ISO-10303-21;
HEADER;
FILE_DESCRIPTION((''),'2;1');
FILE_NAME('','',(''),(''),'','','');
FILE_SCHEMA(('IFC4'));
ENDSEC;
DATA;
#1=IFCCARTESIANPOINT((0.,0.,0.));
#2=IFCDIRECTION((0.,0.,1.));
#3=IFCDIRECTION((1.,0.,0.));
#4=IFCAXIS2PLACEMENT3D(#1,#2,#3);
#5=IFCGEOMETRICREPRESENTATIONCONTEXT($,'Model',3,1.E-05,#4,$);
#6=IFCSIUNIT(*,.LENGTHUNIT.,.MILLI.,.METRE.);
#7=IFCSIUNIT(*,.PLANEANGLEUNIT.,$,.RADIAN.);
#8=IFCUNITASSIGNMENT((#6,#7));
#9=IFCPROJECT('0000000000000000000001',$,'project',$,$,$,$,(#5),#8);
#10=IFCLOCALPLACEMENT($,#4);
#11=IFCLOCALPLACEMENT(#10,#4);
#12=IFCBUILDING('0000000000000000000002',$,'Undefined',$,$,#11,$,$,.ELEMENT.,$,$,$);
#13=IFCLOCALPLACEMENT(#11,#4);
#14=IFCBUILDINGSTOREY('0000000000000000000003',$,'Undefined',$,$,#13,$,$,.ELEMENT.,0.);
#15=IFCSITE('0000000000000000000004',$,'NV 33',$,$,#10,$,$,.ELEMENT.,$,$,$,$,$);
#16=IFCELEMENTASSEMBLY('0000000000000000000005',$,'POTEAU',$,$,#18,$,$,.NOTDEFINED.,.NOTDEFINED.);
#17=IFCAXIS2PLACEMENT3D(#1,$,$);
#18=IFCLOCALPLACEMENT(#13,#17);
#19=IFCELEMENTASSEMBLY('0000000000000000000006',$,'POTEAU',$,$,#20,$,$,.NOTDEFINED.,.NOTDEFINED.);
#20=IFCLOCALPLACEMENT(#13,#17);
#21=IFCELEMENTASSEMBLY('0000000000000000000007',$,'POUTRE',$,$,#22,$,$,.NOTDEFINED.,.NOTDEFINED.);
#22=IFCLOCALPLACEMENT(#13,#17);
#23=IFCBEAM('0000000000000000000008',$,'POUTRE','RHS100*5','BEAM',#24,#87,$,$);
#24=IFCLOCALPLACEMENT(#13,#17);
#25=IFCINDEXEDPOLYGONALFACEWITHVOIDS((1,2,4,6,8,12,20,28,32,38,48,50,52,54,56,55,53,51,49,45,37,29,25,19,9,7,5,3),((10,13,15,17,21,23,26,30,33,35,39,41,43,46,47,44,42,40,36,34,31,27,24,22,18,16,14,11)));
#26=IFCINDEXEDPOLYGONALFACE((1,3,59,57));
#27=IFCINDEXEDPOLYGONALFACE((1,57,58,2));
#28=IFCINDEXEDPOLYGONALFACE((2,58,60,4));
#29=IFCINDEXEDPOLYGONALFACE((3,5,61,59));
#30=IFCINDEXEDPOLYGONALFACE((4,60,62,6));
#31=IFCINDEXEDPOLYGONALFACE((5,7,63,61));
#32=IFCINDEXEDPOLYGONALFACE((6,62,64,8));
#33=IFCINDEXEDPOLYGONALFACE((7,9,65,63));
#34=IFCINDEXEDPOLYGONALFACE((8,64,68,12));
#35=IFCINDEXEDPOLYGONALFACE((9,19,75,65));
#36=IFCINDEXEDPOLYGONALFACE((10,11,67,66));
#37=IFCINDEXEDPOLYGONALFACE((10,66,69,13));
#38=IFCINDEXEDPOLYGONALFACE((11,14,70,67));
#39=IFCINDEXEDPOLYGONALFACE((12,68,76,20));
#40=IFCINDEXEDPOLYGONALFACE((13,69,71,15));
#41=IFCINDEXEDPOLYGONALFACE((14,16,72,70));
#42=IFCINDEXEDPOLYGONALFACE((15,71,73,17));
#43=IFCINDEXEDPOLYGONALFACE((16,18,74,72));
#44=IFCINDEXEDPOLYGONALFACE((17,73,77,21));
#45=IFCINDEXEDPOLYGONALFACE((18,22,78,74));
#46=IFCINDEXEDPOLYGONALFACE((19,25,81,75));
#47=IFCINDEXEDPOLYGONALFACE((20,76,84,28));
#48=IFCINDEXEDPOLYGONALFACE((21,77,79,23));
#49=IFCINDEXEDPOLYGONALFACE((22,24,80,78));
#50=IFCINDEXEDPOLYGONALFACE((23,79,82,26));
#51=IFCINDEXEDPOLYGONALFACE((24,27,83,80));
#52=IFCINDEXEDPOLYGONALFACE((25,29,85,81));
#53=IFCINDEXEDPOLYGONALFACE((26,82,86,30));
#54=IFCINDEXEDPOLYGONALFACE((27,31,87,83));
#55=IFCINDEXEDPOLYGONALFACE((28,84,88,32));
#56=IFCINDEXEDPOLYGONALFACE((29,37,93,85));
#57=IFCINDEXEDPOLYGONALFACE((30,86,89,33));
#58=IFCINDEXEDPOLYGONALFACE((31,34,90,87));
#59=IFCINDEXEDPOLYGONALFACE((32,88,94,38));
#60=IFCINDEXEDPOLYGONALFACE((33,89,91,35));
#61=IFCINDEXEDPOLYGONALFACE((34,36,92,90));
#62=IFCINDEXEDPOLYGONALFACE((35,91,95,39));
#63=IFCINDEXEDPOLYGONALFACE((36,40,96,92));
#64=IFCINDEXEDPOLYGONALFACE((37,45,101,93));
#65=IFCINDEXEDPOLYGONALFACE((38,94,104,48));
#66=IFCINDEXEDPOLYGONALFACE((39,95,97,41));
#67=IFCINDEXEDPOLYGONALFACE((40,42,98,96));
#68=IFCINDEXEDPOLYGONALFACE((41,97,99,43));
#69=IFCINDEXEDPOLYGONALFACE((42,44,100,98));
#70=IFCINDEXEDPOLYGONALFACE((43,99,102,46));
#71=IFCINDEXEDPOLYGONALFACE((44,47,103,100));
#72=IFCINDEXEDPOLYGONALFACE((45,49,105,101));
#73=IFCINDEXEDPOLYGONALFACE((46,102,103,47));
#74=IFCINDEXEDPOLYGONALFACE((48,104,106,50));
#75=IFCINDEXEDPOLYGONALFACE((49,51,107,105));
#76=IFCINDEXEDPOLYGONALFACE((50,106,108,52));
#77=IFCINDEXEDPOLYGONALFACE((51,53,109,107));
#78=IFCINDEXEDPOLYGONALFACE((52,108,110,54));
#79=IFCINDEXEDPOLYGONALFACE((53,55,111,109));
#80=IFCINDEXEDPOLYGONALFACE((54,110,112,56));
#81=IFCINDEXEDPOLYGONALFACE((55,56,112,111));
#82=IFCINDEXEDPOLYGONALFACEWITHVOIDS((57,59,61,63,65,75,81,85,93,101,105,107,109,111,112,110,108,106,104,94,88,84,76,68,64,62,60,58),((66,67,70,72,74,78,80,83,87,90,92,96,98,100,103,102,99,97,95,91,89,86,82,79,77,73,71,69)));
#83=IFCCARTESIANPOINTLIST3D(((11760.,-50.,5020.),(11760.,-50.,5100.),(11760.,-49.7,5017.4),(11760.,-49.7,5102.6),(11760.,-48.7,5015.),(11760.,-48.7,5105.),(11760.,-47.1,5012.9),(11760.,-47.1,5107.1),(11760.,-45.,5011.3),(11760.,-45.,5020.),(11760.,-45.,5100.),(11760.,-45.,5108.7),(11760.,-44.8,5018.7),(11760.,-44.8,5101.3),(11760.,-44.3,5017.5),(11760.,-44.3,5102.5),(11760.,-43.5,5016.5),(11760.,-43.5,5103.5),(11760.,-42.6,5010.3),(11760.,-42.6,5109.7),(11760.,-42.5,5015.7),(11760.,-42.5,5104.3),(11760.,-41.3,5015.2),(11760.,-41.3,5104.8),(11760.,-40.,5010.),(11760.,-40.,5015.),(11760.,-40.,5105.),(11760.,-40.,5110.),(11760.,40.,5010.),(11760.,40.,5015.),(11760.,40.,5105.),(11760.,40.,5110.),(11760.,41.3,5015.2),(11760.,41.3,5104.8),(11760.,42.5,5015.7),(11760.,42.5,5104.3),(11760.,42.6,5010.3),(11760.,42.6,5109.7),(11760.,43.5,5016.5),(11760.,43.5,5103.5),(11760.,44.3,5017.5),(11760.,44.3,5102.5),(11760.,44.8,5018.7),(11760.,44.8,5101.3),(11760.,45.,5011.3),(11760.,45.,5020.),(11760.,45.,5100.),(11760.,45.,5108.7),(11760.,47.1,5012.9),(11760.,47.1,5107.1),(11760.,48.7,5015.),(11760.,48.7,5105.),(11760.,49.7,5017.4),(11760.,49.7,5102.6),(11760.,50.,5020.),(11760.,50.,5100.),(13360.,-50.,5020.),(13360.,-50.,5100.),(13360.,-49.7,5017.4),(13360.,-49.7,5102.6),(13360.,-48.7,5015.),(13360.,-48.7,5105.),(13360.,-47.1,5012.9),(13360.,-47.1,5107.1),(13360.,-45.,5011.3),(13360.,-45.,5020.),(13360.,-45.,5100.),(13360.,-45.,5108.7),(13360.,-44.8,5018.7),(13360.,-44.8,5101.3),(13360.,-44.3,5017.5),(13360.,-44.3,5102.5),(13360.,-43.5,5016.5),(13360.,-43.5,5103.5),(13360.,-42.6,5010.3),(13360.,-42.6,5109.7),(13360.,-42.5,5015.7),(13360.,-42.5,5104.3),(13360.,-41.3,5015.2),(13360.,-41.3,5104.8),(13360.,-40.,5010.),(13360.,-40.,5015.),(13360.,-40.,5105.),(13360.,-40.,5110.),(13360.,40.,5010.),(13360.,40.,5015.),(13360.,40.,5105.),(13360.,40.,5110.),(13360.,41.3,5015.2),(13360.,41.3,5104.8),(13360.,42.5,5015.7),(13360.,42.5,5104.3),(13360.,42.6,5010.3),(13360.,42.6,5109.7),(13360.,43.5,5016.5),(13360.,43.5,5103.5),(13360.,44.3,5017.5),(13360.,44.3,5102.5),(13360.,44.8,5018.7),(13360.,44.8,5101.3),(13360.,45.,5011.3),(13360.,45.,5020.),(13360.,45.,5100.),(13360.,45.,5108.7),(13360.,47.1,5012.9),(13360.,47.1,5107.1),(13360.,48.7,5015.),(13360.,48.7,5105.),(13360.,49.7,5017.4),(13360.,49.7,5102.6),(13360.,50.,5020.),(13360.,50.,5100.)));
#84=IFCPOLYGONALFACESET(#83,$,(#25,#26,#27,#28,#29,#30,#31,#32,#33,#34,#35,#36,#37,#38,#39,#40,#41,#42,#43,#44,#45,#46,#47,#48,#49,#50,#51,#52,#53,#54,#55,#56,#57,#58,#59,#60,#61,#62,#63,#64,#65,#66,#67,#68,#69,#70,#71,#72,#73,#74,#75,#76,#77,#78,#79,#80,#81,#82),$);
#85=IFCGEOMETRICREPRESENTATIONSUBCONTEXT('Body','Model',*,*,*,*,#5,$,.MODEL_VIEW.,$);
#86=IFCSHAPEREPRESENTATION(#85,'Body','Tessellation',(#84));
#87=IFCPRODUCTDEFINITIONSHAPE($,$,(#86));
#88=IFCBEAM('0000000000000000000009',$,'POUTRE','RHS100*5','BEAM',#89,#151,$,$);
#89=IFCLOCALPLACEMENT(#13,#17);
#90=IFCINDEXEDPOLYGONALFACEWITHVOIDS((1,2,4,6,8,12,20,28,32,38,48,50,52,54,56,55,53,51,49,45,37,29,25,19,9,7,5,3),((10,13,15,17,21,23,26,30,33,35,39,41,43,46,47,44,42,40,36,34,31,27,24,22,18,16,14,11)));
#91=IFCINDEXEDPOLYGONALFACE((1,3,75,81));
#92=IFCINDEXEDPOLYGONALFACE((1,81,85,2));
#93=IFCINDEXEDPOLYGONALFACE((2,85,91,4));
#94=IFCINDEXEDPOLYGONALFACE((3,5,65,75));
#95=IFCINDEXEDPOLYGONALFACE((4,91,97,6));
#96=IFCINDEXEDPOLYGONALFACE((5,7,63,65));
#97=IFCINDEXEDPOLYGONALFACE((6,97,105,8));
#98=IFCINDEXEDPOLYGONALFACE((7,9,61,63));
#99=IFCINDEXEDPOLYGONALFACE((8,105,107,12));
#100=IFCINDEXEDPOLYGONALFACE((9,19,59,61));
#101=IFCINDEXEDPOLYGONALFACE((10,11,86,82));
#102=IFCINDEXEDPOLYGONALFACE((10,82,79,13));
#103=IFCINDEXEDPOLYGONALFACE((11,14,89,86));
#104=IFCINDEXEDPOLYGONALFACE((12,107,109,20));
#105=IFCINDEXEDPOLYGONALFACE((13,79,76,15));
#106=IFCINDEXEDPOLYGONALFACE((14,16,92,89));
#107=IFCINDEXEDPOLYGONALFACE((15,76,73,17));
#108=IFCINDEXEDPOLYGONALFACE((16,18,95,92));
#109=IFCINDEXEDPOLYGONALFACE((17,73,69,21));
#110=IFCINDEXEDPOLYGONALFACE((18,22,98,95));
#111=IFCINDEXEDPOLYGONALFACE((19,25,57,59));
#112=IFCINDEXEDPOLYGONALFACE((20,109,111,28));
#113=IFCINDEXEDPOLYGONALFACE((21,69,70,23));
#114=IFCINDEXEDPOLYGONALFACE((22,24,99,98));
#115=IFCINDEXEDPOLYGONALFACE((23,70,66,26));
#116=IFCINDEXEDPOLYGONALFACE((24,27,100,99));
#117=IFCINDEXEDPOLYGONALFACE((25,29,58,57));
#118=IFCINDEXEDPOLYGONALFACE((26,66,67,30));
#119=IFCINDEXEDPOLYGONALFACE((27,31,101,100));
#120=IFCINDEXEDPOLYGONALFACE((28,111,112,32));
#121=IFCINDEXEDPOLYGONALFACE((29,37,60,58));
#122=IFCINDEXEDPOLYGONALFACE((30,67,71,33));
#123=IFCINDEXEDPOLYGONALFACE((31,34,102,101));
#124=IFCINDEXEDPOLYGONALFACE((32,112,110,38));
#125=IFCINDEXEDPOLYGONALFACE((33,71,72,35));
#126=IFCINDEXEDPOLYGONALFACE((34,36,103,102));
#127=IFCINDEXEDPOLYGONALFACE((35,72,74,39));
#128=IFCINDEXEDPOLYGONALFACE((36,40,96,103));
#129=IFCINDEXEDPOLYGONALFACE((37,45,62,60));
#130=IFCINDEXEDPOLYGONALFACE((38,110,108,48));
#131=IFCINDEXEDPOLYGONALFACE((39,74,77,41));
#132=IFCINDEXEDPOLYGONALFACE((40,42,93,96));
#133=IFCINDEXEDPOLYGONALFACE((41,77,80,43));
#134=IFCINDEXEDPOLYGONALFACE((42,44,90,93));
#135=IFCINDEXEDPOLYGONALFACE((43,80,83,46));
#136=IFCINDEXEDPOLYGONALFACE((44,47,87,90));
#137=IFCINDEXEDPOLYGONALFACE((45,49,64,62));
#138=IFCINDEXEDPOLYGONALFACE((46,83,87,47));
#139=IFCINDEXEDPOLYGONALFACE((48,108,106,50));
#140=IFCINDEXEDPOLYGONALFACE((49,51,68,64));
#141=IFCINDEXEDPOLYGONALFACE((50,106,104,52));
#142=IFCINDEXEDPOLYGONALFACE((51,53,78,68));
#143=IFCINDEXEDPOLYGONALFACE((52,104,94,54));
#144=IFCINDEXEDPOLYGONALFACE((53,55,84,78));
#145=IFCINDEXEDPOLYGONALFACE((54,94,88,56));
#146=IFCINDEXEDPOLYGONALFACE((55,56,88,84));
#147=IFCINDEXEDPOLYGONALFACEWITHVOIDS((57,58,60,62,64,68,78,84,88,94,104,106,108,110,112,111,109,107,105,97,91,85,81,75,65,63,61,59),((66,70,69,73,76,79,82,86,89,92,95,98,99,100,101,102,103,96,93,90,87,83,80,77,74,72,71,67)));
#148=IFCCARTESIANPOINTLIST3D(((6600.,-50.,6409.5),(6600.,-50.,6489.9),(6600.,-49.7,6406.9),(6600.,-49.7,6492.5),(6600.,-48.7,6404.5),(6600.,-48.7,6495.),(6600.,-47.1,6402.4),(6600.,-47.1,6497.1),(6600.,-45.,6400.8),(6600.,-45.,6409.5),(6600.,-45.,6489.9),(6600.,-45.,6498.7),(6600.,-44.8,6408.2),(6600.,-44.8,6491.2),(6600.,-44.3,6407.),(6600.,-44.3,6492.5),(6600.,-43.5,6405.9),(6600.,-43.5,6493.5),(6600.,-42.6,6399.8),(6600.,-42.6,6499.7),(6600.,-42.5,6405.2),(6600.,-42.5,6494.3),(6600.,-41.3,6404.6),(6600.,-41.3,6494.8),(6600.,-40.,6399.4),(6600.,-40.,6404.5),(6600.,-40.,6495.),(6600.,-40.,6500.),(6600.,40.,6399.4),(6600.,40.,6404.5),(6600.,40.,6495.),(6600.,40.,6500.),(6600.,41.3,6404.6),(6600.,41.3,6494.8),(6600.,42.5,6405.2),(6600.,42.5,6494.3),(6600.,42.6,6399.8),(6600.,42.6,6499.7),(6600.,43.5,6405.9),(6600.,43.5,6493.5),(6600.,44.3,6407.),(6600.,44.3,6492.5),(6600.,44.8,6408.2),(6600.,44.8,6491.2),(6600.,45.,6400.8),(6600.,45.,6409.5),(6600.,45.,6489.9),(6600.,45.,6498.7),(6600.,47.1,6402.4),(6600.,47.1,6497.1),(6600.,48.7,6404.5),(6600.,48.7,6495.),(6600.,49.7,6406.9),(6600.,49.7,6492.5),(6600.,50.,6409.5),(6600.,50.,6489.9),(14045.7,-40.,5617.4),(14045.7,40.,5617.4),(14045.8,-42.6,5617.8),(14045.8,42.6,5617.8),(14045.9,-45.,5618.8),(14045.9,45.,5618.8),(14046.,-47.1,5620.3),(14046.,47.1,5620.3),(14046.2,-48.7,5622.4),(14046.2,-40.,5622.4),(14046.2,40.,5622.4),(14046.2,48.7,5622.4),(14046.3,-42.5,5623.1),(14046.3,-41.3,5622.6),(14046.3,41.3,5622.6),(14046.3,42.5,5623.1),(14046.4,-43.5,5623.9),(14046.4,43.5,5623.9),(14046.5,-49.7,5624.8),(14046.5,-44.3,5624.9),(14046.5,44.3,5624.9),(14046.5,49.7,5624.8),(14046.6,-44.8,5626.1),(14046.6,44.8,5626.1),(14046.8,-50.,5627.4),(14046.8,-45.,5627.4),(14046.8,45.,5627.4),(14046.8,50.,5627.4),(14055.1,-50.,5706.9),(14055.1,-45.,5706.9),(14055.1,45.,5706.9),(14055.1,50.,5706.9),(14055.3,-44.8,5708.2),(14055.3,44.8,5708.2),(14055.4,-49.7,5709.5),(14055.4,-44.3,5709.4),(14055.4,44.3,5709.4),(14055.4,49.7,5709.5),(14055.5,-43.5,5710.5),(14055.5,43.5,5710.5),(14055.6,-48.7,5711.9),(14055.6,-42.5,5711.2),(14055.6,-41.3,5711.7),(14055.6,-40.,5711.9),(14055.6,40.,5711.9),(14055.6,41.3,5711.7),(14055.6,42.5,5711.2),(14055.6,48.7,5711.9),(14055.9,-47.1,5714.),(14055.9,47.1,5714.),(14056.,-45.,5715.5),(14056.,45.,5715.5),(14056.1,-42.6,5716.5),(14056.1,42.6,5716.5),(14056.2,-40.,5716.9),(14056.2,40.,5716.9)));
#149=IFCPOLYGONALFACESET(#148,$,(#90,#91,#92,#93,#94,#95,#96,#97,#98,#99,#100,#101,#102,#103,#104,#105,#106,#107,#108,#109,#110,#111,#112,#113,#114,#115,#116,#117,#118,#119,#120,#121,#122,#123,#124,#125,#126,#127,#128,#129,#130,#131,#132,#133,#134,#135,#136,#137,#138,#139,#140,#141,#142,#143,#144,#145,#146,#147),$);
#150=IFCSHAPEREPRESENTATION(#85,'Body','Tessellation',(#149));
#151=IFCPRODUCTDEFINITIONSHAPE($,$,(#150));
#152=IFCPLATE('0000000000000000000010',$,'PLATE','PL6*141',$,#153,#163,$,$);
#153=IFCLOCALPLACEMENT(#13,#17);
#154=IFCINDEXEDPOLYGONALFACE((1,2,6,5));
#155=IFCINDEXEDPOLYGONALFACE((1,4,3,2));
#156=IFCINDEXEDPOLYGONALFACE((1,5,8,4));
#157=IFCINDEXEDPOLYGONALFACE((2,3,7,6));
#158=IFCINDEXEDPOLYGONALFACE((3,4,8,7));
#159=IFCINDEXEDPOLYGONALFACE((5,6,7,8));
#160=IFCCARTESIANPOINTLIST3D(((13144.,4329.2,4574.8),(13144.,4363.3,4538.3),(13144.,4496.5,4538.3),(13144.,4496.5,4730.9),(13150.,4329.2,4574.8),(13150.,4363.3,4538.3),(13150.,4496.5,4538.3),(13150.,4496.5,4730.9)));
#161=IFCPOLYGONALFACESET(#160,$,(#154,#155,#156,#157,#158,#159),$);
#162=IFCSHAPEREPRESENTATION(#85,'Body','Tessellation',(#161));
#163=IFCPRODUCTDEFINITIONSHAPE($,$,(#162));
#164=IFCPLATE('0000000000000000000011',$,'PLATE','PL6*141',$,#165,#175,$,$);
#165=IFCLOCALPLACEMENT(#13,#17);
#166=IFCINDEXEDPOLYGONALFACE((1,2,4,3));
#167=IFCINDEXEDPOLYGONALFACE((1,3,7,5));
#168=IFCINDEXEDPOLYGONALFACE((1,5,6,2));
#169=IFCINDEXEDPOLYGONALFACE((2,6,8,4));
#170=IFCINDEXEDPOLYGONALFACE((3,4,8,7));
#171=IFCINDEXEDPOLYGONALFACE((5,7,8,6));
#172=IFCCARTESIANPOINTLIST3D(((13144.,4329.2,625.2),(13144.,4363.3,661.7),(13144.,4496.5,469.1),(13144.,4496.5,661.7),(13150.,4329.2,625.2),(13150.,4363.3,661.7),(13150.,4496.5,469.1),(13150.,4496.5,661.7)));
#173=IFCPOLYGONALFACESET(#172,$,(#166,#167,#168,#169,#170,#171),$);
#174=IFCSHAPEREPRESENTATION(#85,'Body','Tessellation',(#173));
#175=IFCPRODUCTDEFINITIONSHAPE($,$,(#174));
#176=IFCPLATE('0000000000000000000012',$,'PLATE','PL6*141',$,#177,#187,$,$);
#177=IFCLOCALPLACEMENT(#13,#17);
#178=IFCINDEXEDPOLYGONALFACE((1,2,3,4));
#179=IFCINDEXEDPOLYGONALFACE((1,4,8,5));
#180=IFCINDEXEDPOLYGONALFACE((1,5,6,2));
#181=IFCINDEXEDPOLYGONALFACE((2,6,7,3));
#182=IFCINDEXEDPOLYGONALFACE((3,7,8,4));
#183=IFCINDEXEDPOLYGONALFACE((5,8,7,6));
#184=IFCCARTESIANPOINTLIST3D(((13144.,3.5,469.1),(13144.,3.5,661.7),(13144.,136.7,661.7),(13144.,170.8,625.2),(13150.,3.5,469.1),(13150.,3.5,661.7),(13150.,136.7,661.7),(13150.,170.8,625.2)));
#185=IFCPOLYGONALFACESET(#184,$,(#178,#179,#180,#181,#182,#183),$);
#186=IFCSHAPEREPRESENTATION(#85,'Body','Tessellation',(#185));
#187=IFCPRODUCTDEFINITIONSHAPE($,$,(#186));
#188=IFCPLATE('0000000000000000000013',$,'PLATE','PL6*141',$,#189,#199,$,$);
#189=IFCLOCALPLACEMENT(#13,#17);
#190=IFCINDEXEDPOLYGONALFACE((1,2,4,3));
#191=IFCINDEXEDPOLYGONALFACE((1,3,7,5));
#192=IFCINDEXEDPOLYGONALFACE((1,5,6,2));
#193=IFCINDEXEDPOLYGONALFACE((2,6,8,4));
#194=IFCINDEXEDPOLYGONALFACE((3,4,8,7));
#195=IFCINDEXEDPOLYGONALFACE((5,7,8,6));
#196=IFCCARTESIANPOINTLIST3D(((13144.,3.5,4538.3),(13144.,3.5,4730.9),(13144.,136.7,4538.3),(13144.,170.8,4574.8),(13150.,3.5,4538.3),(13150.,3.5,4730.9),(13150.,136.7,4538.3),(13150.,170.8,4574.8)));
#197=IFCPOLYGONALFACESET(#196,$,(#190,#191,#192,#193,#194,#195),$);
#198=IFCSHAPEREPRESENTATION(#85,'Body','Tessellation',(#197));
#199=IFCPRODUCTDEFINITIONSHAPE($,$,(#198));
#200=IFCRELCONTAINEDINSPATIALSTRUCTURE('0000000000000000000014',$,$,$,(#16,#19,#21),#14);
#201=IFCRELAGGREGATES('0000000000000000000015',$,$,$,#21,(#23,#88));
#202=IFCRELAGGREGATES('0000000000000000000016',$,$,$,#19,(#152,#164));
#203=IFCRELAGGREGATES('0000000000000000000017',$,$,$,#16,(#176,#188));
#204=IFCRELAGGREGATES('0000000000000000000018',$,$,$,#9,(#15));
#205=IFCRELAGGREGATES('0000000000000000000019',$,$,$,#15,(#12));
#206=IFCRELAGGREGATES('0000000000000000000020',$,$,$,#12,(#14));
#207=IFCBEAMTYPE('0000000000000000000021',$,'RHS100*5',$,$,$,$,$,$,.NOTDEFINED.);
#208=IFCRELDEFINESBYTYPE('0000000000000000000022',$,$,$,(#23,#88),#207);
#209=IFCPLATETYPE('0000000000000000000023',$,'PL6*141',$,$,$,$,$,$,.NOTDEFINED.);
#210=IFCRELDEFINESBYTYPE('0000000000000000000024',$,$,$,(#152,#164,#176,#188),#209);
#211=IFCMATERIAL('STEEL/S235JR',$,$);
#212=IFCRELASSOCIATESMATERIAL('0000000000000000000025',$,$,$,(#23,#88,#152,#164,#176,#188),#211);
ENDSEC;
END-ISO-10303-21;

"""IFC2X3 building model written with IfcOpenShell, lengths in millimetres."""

from ifc_helpers import new_model, si_unit, frame, origin_with_axes, origin_2d_with_axis, place, context, subcontext, project, spatial, polyline, hollow_rectangle, outline, extrude, clip, halfspace, material, type_object, element, aggregate, save


model = new_model("IFC2X3")

# Units and contexts
model_context = context("Model", 3, precision=1e-05, world=origin_with_axes())
body_context = subcontext(model_context, "Body", "Model", "MODEL_VIEW")
ifc_project = project(units=[si_unit("LENGTHUNIT", "METRE", prefix="MILLI"), si_unit("PLANEANGLEUNIT", "RADIAN")], contexts=[model_context])

# Site, building, storey
site_placement = place(None, origin_with_axes())
site = spatial("IfcSite", under=ifc_project, at=site_placement, Name="NV 33", CompositionType="ELEMENT")
building_placement = place(site_placement, origin_with_axes())
building = spatial("IfcBuilding", under=site, at=building_placement, Name="Undefined", CompositionType="ELEMENT")
storey_placement = place(building_placement, origin_with_axes())
storey = spatial("IfcBuildingStorey", under=building, at=storey_placement, Name="Undefined", CompositionType="ELEMENT", Elevation=0.0)

# Element assembly
assembly_1_placement = place(storey_placement, origin_with_axes())
assembly_1 = element("IfcElementAssembly", 1, at=assembly_1_placement, inside=storey, Name="POTEAU", AssemblyPlace="NOTDEFINED", PredefinedType="NOTDEFINED")
ifc_material_1 = material(Name="STEEL/S235JR")

# Element assembly
assembly_2_placement = place(storey_placement, origin_with_axes())
assembly_2 = element("IfcElementAssembly", 2, at=assembly_2_placement, inside=storey, Name="POTEAU", AssemblyPlace="NOTDEFINED", PredefinedType="NOTDEFINED")

# Shared definitions
beam_type_1 = type_object("IfcBeamType", Name="RHS100*5", PredefinedType="NOTDEFINED")

# Element assembly, beams
assembly_3_placement = place(storey_placement, origin_with_axes())
assembly_3 = element("IfcElementAssembly", 3, at=assembly_3_placement, inside=storey, Name="POUTRE", AssemblyPlace="NOTDEFINED", PredefinedType="NOTDEFINED")
beam_1_placement = place(assembly_3_placement, frame((13360.0, 0.0, 5060.0), z_axis=(0.0, -1.0, 0.0), x_axis=(-1.0, 0.0, 0.0)))
beam_1 = element("IfcBeam", 4, at=beam_1_placement, type_object=beam_type_1, material=ifc_material_1, Name="POUTRE", Description="RHS100*5", ObjectType="BEAM", context=body_context, shape_type="SweptSolid", body=[
    extrude(hollow_rectangle(XDim=100.0, YDim=100.0, WallThickness=5.0, InnerFilletRadius=5.0, OuterFilletRadius=10.0, at=origin_2d_with_axis()), frame((1600.0, 0.0, 0.0), z_axis=(-1.0, 0.0, 0.0), x_axis=(0.0, -1.0, 0.0)), (0.0, 0.0, 1.0), 1600.0),
])
beam_2_placement = place(assembly_3_placement, frame((14050.9, 0.0, 5667.2), z_axis=(-0.104455, 0.0, -0.99453), x_axis=(-0.99453, 0.0, 0.104455)))
beam_2 = element("IfcBeam", 5, at=beam_2_placement, type_object=beam_type_1, material=ifc_material_1, Name="POUTRE", Description="RHS100*5", ObjectType="BEAM", context=body_context, shape_type="Clipping", body=[
    clip(extrude(hollow_rectangle(XDim=100.0, YDim=100.0, WallThickness=5.0, InnerFilletRadius=5.0, OuterFilletRadius=10.0, at=origin_2d_with_axis()), frame((7527.2, 0.0, 0.0), z_axis=(-1.0, 0.0, 0.0), x_axis=(0.0, -1.0, 0.0)), (0.0, 0.0, 1.0), 7527.2), halfspace(frame((7497.2, 50.0, -50.0), z_axis=(0.99453, 0.0, 0.104455), x_axis=(0.0, -1.0, 0.0)), False)),
])
aggregate(assembly_3, [beam_1, beam_2])

# Plates
plate_type_1 = type_object("IfcPlateType", Name="PL6*141", PredefinedType="NOTDEFINED")
plate_1_placement = place(assembly_2_placement, frame((13147.0, 4496.5, 4538.3), z_axis=(1.0, 0.0, 0.0), x_axis=(0.0, 0.0, 1.0)))
plate_1 = element("IfcPlate", 6, at=plate_1_placement, type_object=plate_type_1, material=ifc_material_1, Name="PLATE", Description="PL6*141", context=body_context, shape_type="SweptSolid", body=[
    extrude(outline(polyline([(0.0, 0.0), (192.6, 0.0), (36.6, 167.2), (0.0, 133.1), (0.0, 0.0)])), frame((0.0, 0.0, -3.0), z_axis=(0.0, 0.0, 1.0), x_axis=(1.0, 0.0, 0.0)), (0.0, 0.0, 1.0), 6.0),
])
plate_2_placement = place(assembly_2_placement, frame((13147.0, 4496.5, 469.1), z_axis=(1.0, 0.0, 0.0), x_axis=(0.0, 0.0, 1.0)))
plate_2 = element("IfcPlate", 7, at=plate_2_placement, type_object=plate_type_1, material=ifc_material_1, Name="PLATE", Description="PL6*141", context=body_context, shape_type="SweptSolid", body=[
    extrude(outline(polyline([(0.0, 0.0), (192.6, 0.0), (192.6, 133.1), (156.1, 167.2), (0.0, 0.0)])), frame((0.0, 0.0, -3.0), z_axis=(0.0, 0.0, 1.0), x_axis=(1.0, 0.0, 0.0)), (0.0, 0.0, 1.0), 6.0),
])
plate_3_placement = place(assembly_1_placement, frame((13147.0, 3.5, 661.7), z_axis=(1.0, 0.0, 0.0), x_axis=(0.0, 0.0, -1.0)))
plate_3 = element("IfcPlate", 8, at=plate_3_placement, type_object=plate_type_1, material=ifc_material_1, Name="PLATE", Description="PL6*141", context=body_context, shape_type="SweptSolid", body=[
    extrude(outline(polyline([(0.0, 0.0), (192.6, 0.0), (36.6, 167.2), (0.0, 133.1), (0.0, 0.0)])), frame((0.0, 0.0, -3.0), z_axis=(0.0, 0.0, 1.0), x_axis=(1.0, 0.0, 0.0)), (0.0, 0.0, 1.0), 6.0),
])
plate_4_placement = place(assembly_1_placement, frame((13147.0, 3.5, 4730.9), z_axis=(1.0, 0.0, 0.0), x_axis=(0.0, 0.0, -1.0)))
plate_4 = element("IfcPlate", 9, at=plate_4_placement, type_object=plate_type_1, material=ifc_material_1, Name="PLATE", Description="PL6*141", context=body_context, shape_type="SweptSolid", body=[
    extrude(outline(polyline([(0.0, 0.0), (192.6, 0.0), (192.6, 133.1), (156.1, 167.2), (0.0, 0.0)])), frame((0.0, 0.0, -3.0), z_axis=(0.0, 0.0, 1.0), x_axis=(1.0, 0.0, 0.0)), (0.0, 0.0, 1.0), 6.0),
])

aggregate(assembly_2, [plate_1, plate_2])
aggregate(assembly_1, [plate_3, plate_4])

save(model, "model.ifc")
